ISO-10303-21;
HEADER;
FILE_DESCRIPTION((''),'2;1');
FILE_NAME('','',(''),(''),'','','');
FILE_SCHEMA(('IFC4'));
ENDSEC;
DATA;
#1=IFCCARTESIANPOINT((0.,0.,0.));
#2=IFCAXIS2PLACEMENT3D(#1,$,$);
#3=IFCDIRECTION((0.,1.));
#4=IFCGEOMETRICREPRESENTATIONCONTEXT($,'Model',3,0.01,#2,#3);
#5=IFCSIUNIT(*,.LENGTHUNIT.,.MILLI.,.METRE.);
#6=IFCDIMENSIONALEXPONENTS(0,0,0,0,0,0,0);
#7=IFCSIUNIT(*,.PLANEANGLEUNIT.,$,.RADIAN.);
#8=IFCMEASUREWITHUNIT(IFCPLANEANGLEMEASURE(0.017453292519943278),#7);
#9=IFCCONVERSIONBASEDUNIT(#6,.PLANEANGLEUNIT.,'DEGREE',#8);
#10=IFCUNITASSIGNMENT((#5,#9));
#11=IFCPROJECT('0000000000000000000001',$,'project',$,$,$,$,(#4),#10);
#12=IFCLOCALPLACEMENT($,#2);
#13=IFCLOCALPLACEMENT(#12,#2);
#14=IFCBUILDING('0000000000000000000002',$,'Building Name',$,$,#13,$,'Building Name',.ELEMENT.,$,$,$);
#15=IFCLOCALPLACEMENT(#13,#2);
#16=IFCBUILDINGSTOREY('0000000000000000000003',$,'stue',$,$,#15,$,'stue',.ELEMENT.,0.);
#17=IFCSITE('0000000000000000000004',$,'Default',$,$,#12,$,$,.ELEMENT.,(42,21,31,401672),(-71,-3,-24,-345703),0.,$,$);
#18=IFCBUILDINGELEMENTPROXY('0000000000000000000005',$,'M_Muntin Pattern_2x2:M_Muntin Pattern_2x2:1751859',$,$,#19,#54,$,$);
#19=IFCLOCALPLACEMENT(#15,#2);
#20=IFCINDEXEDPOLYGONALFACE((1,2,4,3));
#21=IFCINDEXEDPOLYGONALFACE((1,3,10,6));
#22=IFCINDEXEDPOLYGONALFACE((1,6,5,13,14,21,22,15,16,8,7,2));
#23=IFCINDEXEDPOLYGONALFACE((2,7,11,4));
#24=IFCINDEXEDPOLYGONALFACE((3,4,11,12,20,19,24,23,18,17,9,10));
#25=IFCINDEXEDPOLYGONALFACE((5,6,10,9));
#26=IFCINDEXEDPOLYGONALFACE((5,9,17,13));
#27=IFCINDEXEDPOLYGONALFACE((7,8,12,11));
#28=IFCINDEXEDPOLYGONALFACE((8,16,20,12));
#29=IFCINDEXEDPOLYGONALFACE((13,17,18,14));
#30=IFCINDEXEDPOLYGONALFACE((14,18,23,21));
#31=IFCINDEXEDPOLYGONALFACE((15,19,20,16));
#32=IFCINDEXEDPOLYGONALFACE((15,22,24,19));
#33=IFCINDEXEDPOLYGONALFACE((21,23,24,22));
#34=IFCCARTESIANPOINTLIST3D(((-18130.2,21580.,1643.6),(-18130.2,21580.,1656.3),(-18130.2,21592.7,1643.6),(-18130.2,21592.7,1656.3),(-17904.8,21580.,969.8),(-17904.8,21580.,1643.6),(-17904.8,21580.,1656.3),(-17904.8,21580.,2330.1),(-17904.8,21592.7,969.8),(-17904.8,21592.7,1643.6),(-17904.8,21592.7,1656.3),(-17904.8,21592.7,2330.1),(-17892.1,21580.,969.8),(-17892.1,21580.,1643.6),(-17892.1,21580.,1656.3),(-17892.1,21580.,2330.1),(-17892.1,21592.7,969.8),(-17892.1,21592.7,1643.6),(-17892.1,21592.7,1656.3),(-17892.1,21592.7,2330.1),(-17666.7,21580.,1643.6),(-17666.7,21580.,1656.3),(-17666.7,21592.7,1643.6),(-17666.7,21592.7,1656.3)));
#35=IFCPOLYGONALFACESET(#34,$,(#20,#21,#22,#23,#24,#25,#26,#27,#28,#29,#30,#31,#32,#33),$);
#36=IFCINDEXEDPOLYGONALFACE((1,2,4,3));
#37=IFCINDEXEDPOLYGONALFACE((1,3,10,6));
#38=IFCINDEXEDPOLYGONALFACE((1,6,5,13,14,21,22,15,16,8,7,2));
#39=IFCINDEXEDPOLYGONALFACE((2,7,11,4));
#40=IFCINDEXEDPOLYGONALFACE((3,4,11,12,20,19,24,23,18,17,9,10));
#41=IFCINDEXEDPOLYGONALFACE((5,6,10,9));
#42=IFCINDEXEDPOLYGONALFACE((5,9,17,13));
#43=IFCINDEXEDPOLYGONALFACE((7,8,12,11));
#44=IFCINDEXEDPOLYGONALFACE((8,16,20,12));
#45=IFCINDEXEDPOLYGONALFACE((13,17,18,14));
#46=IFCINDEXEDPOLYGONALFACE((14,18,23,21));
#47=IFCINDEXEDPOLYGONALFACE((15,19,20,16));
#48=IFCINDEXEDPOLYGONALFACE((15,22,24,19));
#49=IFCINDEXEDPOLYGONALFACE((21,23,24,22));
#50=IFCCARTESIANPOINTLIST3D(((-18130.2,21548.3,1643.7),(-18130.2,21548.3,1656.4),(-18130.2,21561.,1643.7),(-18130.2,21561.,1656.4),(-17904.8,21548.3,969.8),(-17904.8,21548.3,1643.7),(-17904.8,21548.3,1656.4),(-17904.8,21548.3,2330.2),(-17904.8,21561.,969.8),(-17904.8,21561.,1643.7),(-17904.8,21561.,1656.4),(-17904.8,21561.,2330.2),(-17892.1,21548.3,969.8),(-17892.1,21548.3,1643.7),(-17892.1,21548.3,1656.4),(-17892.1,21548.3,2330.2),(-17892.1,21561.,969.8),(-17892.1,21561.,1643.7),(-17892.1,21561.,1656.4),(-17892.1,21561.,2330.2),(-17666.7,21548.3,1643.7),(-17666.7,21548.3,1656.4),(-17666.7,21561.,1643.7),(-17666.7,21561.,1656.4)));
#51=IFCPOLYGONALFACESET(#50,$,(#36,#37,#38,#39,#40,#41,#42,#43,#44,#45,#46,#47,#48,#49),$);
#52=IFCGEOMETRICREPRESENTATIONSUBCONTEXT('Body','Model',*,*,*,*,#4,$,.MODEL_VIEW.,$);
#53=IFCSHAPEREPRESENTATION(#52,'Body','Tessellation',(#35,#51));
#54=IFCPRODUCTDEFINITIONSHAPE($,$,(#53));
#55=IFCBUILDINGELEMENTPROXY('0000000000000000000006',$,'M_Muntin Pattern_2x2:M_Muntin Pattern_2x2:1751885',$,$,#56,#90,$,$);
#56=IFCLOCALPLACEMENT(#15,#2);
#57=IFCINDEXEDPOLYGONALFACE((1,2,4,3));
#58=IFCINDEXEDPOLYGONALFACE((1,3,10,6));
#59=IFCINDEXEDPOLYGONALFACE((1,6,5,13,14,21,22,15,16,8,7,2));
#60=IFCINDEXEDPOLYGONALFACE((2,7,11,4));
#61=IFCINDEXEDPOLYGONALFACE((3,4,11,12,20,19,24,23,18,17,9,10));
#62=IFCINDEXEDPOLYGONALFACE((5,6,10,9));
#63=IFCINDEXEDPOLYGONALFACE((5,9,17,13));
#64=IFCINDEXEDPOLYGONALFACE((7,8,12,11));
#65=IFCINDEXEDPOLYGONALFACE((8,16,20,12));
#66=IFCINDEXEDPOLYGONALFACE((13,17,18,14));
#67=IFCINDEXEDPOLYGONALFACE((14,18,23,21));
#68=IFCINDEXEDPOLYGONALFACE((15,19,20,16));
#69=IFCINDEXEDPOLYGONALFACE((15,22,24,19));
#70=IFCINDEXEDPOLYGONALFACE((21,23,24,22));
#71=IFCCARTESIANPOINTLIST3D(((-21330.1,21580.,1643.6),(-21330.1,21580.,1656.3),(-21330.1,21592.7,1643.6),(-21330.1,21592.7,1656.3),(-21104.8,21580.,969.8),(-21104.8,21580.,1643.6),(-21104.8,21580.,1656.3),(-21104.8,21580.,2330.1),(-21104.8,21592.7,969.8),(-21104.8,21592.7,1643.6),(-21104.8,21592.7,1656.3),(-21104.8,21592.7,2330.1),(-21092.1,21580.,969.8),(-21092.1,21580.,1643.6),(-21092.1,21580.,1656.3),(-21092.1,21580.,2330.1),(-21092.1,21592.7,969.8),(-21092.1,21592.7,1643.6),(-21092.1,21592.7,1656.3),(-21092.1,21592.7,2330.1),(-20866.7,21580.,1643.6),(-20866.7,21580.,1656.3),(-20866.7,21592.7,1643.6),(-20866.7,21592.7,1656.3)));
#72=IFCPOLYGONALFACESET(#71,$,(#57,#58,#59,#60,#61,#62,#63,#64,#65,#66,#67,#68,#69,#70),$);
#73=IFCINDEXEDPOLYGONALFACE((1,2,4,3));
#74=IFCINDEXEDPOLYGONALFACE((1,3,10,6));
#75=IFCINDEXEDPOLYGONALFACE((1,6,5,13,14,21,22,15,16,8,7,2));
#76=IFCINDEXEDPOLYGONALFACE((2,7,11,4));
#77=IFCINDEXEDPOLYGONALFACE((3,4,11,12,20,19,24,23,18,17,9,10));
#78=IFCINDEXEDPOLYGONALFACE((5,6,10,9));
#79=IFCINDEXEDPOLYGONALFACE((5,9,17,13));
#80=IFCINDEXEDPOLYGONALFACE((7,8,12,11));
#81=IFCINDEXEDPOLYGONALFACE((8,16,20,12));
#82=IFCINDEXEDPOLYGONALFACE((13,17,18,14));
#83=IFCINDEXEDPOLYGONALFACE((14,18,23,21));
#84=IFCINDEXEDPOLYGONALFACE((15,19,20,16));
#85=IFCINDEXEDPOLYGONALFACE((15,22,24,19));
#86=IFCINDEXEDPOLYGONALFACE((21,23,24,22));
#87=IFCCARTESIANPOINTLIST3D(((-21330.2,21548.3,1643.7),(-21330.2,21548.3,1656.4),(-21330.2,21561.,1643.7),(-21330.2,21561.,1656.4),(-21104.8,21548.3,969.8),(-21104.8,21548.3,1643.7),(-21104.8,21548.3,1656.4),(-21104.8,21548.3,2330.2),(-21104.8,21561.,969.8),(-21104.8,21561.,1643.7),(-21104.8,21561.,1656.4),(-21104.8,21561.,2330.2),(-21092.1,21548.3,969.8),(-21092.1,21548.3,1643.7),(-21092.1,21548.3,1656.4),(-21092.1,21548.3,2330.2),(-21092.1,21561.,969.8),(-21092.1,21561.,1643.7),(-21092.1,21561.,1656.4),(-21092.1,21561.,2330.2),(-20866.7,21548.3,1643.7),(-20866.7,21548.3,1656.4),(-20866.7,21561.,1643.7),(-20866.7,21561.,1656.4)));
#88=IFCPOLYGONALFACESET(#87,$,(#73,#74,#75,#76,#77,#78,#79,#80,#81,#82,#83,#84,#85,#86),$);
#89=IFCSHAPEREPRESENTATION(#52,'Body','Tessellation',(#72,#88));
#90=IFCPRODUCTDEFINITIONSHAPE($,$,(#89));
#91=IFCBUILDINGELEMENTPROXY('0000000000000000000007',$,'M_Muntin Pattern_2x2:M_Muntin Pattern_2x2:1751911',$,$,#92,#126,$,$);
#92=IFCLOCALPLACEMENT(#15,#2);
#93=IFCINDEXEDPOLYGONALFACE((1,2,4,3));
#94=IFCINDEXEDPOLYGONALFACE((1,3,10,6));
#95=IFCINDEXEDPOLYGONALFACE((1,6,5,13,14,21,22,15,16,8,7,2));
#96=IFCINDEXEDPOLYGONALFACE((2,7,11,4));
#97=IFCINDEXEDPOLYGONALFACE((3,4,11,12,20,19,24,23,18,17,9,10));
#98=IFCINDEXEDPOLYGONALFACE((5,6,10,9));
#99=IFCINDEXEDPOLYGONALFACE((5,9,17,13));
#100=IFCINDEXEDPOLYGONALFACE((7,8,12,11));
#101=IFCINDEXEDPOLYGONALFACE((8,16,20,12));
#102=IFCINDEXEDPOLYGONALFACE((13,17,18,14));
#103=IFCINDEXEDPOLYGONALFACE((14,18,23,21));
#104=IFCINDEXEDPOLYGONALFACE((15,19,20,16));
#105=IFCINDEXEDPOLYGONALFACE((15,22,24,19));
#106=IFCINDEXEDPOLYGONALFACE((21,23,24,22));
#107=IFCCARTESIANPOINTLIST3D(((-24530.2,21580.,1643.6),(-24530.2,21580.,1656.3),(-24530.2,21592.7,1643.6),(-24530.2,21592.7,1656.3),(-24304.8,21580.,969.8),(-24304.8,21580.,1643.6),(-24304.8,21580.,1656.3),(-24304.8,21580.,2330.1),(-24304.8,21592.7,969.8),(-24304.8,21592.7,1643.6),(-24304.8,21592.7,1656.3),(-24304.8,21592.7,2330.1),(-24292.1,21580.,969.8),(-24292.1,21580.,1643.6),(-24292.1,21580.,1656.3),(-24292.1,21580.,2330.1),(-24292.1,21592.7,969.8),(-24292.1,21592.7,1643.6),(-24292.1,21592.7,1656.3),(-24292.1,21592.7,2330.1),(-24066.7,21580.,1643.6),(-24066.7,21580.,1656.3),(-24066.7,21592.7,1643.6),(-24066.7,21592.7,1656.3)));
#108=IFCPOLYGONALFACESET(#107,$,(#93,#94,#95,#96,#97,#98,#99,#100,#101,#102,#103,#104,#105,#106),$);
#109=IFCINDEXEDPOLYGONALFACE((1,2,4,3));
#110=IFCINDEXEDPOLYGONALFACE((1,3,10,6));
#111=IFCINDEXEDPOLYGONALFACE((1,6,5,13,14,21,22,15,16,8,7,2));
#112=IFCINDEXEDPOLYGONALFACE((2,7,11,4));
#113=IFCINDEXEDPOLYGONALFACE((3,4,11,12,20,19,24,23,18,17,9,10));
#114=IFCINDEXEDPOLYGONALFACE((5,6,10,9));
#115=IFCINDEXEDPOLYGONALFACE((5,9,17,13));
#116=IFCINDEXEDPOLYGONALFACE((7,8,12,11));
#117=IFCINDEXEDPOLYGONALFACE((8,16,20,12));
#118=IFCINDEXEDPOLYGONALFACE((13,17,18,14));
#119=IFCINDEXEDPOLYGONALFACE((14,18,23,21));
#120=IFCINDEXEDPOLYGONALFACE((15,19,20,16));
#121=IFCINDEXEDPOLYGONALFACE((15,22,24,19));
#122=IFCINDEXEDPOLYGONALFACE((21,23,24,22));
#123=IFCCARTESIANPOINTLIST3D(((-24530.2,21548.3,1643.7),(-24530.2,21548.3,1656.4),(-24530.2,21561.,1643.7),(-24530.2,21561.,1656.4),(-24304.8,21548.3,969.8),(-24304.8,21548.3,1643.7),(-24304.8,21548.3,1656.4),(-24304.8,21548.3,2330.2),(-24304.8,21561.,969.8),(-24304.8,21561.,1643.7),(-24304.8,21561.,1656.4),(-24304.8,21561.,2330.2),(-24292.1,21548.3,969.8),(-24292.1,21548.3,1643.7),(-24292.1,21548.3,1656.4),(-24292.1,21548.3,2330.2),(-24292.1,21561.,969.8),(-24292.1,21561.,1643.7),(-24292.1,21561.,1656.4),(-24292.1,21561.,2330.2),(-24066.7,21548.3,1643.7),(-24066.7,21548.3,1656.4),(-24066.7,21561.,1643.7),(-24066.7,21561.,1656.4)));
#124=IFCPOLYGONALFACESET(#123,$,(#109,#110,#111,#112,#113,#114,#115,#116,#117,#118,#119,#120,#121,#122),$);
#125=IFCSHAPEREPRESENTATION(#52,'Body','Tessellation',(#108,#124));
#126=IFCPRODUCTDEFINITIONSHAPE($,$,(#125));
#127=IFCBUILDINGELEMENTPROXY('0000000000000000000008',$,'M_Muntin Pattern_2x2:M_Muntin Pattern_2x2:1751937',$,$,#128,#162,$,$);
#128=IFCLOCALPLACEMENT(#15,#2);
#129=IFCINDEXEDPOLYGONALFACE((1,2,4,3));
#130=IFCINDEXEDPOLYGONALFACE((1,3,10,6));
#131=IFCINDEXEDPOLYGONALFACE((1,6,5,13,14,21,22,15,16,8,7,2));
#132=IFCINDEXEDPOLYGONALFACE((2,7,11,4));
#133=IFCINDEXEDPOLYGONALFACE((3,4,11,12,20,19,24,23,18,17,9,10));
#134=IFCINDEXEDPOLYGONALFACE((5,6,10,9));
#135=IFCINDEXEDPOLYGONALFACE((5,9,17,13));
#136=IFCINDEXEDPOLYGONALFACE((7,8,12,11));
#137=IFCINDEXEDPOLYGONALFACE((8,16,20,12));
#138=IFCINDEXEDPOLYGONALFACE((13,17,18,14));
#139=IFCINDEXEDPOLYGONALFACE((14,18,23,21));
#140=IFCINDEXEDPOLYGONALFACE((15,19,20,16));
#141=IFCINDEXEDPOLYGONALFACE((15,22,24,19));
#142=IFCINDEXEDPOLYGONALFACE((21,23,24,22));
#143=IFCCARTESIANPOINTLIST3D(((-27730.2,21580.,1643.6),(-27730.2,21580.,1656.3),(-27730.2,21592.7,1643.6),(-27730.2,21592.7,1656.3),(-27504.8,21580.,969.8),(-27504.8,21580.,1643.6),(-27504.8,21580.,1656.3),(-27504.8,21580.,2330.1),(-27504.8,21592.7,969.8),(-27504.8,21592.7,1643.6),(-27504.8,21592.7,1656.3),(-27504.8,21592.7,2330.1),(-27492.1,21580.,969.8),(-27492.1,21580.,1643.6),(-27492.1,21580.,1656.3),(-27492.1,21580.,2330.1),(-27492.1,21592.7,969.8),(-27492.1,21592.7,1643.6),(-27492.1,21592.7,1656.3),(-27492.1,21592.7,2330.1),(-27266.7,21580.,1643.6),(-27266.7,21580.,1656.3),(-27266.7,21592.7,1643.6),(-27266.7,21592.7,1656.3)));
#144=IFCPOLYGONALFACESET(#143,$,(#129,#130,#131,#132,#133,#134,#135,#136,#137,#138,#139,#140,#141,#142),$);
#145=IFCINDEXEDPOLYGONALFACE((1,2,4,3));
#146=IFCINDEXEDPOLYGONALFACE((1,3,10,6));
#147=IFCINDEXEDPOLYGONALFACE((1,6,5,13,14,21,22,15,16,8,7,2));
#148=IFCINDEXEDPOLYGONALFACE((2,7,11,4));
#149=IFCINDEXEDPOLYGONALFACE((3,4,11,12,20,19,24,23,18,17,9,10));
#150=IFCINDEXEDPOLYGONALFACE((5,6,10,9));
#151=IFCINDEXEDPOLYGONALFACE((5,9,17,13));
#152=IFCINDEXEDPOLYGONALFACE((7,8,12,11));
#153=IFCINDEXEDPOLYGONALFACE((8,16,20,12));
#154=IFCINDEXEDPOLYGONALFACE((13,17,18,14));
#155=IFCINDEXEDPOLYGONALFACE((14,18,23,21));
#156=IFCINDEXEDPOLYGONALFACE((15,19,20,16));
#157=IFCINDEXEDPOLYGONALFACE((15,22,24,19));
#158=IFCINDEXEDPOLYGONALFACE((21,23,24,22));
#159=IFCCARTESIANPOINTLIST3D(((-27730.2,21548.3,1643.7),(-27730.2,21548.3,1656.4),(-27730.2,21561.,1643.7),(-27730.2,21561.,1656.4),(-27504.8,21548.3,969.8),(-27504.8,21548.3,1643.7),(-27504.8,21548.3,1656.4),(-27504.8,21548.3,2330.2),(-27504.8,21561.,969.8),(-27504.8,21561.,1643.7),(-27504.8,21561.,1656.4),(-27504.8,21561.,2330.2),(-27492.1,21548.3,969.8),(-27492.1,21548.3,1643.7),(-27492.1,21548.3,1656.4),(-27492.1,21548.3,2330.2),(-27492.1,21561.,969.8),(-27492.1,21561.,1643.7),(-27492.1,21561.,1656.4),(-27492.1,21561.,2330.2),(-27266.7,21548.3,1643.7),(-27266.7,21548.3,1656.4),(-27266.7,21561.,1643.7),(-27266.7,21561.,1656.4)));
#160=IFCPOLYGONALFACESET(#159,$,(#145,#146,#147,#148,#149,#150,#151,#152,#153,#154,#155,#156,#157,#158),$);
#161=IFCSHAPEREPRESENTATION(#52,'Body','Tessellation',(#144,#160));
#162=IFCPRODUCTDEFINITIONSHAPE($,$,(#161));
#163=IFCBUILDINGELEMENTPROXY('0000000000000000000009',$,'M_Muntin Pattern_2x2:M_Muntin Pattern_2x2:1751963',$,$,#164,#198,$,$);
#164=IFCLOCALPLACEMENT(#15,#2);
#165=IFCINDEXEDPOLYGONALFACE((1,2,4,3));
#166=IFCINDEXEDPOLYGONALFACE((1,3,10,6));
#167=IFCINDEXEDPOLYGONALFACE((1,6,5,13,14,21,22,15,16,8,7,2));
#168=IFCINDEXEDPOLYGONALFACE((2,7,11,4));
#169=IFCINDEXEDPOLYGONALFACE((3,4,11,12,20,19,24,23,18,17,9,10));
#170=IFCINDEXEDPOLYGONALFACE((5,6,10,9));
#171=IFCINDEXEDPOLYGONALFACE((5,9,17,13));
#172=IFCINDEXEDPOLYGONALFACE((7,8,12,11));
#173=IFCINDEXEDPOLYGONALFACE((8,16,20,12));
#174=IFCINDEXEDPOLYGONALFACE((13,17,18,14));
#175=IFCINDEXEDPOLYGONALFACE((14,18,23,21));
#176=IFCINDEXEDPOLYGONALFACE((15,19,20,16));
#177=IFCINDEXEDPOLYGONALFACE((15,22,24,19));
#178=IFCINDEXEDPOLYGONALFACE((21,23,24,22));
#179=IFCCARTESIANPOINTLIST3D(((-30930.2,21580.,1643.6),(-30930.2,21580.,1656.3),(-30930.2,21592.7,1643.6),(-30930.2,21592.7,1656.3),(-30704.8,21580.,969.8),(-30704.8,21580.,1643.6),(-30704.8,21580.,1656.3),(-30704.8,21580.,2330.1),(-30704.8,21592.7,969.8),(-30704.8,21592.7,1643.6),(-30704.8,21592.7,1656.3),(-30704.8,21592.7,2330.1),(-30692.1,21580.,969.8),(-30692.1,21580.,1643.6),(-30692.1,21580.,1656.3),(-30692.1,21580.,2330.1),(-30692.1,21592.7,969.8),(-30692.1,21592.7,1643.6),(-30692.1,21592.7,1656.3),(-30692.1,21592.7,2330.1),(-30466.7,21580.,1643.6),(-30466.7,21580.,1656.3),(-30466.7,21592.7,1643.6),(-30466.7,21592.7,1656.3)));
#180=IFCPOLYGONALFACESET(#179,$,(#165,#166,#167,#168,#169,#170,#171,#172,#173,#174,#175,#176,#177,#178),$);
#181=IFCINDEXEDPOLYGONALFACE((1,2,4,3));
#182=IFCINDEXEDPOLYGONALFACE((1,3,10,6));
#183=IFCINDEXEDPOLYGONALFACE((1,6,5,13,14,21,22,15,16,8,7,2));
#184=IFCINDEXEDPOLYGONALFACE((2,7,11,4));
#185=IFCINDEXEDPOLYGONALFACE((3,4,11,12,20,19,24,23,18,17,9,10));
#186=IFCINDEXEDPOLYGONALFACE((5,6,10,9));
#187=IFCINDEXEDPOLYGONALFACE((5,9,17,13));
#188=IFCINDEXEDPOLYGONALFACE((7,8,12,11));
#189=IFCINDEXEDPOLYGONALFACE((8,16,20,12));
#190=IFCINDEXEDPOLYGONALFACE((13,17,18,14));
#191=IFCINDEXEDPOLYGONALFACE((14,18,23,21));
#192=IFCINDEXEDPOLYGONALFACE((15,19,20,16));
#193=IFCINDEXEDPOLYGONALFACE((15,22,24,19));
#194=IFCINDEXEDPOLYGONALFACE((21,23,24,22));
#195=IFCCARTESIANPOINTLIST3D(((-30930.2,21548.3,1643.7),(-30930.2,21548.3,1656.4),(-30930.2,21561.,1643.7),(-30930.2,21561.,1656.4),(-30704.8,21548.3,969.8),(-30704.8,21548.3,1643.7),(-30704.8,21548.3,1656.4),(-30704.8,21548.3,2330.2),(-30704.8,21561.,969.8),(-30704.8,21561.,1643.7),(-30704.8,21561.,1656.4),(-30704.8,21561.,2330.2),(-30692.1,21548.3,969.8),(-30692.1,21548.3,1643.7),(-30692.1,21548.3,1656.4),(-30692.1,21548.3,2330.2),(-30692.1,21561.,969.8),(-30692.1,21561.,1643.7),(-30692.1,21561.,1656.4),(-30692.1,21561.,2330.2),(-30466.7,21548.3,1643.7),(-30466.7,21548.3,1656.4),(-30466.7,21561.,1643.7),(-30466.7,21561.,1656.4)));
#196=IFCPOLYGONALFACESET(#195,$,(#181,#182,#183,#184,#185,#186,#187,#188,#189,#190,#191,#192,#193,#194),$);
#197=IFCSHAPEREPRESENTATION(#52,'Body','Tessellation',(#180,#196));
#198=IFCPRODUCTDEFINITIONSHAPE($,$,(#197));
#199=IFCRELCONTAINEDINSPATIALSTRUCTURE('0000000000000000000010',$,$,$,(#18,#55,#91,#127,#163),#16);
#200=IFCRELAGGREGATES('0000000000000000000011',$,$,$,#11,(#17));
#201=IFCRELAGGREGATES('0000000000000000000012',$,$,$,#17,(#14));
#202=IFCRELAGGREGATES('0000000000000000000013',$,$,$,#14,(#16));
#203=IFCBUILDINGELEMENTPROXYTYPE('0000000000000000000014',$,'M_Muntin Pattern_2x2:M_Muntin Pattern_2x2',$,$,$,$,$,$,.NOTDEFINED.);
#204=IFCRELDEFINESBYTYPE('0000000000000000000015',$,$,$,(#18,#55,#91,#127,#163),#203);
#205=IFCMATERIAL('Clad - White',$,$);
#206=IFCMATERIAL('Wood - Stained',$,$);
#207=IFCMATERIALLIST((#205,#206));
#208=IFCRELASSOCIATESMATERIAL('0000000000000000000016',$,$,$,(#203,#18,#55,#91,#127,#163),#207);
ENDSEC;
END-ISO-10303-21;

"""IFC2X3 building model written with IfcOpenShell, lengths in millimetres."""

from ifc_helpers import new_model, entity, si_unit, converted_unit, direction, frame, origin, place, context, subcontext, project, spatial, polyline, outline, extrude, source, transform, mapped, material, material_list, type_object, type_shapes, element, save


model = new_model("IFC2X3")

# Units and contexts
model_context = context("Model", 3, precision=0.01, world=origin(), true_north=direction((0.0, 1.0)))
body_context = subcontext(model_context, "Body", "Model", "MODEL_VIEW")
ifc_project = project(units=[si_unit("LENGTHUNIT", "METRE", prefix="MILLI"), converted_unit("PLANEANGLEUNIT", "DEGREE", entity("IfcPlaneAngleMeasure", 0.017453292519943278), si_unit("PLANEANGLEUNIT", "RADIAN"), dimensions=[0, 0, 0, 0, 0, 0, 0])], contexts=[model_context])

# Site, building, storey
site_placement = place(None, origin())
site = spatial("IfcSite", under=ifc_project, at=site_placement, Name="Default", CompositionType="ELEMENT", RefLatitude=(42, 21, 31, 401672), RefLongitude=(-71, -3, -24, -345703), RefElevation=0.0)
building_placement = place(site_placement, origin())
building = spatial("IfcBuilding", under=site, at=building_placement, Name="Building Name", LongName="Building Name", CompositionType="ELEMENT")
storey_placement = place(building_placement, origin())
storey = spatial("IfcBuildingStorey", under=building, at=storey_placement, Name="stue", LongName="stue", CompositionType="ELEMENT", Elevation=0.0)

# Building element proxies
ifc_material_1 = material(Name="Clad - White")
ifc_material_2 = material(Name="Wood - Stained")
ifc_material_list = material_list([ifc_material_1, ifc_material_2])
building_element_proxy_type_1 = type_object("IfcBuildingElementProxyType", Name="M_Muntin Pattern_2x2:M_Muntin Pattern_2x2", PredefinedType="NOTDEFINED", material=ifc_material_list)
shared_shape_1 = source(origin(), body_context, "Body", "SweptSolid", [
    extrude(outline(polyline([(6.4, -6.4), (680.1, -6.4), (680.1, 6.3), (6.4, 6.3), (6.4, 231.7), (-6.3, 231.7), (-6.3, 6.3), (-680.2, 6.3), (-680.2, -6.4), (-6.3, -6.4), (-6.3, -231.7), (6.4, -231.7), (6.4, -6.4)])), frame((0.0, 9.5, 680.1), z_axis=(0.0, 1.0, 0.0), x_axis=(0.0, 0.0, 1.0)), (0.0, 0.0, 1.0), 12.7),
    extrude(outline(polyline([(6.4, -6.4), (680.2, -6.4), (680.2, 6.3), (6.4, 6.3), (6.4, 231.7), (-6.3, 231.7), (-6.3, 6.3), (-680.2, 6.3), (-680.2, -6.4), (-6.3, -6.4), (-6.3, -231.7), (6.4, -231.7), (6.4, -6.4)])), frame((0.0, -22.2, 680.2), z_axis=(0.0, 1.0, 0.0), x_axis=(0.0, 0.0, 1.0)), (0.0, 0.0, 1.0), 12.7),
])
type_shapes(building_element_proxy_type_1, [shared_shape_1])
for number, where, name in (
    (1, (-17898.4, 21570.5, 969.8), "M_Muntin Pattern_2x2:M_Muntin Pattern_2x2:1751859"),
    (2, (-21098.4, 21570.5, 969.8), "M_Muntin Pattern_2x2:M_Muntin Pattern_2x2:1751885"),
    (3, (-24298.4, 21570.5, 969.8), "M_Muntin Pattern_2x2:M_Muntin Pattern_2x2:1751911"),
    (4, (-27498.4, 21570.5, 969.8), "M_Muntin Pattern_2x2:M_Muntin Pattern_2x2:1751937"),
    (5, (-30698.4, 21570.5, 969.8), "M_Muntin Pattern_2x2:M_Muntin Pattern_2x2:1751963"),
):
    element("IfcBuildingElementProxy", number, at=place(storey_placement, frame(where)), inside=storey, type_object=building_element_proxy_type_1, material=ifc_material_list, Name=name, context=body_context, shape_type="MappedRepresentation", body=[
        mapped(shared_shape_1, transform((0.0, 0.0, 0.0), scale=1.0)),
    ])

save(model, "model.ifc")
